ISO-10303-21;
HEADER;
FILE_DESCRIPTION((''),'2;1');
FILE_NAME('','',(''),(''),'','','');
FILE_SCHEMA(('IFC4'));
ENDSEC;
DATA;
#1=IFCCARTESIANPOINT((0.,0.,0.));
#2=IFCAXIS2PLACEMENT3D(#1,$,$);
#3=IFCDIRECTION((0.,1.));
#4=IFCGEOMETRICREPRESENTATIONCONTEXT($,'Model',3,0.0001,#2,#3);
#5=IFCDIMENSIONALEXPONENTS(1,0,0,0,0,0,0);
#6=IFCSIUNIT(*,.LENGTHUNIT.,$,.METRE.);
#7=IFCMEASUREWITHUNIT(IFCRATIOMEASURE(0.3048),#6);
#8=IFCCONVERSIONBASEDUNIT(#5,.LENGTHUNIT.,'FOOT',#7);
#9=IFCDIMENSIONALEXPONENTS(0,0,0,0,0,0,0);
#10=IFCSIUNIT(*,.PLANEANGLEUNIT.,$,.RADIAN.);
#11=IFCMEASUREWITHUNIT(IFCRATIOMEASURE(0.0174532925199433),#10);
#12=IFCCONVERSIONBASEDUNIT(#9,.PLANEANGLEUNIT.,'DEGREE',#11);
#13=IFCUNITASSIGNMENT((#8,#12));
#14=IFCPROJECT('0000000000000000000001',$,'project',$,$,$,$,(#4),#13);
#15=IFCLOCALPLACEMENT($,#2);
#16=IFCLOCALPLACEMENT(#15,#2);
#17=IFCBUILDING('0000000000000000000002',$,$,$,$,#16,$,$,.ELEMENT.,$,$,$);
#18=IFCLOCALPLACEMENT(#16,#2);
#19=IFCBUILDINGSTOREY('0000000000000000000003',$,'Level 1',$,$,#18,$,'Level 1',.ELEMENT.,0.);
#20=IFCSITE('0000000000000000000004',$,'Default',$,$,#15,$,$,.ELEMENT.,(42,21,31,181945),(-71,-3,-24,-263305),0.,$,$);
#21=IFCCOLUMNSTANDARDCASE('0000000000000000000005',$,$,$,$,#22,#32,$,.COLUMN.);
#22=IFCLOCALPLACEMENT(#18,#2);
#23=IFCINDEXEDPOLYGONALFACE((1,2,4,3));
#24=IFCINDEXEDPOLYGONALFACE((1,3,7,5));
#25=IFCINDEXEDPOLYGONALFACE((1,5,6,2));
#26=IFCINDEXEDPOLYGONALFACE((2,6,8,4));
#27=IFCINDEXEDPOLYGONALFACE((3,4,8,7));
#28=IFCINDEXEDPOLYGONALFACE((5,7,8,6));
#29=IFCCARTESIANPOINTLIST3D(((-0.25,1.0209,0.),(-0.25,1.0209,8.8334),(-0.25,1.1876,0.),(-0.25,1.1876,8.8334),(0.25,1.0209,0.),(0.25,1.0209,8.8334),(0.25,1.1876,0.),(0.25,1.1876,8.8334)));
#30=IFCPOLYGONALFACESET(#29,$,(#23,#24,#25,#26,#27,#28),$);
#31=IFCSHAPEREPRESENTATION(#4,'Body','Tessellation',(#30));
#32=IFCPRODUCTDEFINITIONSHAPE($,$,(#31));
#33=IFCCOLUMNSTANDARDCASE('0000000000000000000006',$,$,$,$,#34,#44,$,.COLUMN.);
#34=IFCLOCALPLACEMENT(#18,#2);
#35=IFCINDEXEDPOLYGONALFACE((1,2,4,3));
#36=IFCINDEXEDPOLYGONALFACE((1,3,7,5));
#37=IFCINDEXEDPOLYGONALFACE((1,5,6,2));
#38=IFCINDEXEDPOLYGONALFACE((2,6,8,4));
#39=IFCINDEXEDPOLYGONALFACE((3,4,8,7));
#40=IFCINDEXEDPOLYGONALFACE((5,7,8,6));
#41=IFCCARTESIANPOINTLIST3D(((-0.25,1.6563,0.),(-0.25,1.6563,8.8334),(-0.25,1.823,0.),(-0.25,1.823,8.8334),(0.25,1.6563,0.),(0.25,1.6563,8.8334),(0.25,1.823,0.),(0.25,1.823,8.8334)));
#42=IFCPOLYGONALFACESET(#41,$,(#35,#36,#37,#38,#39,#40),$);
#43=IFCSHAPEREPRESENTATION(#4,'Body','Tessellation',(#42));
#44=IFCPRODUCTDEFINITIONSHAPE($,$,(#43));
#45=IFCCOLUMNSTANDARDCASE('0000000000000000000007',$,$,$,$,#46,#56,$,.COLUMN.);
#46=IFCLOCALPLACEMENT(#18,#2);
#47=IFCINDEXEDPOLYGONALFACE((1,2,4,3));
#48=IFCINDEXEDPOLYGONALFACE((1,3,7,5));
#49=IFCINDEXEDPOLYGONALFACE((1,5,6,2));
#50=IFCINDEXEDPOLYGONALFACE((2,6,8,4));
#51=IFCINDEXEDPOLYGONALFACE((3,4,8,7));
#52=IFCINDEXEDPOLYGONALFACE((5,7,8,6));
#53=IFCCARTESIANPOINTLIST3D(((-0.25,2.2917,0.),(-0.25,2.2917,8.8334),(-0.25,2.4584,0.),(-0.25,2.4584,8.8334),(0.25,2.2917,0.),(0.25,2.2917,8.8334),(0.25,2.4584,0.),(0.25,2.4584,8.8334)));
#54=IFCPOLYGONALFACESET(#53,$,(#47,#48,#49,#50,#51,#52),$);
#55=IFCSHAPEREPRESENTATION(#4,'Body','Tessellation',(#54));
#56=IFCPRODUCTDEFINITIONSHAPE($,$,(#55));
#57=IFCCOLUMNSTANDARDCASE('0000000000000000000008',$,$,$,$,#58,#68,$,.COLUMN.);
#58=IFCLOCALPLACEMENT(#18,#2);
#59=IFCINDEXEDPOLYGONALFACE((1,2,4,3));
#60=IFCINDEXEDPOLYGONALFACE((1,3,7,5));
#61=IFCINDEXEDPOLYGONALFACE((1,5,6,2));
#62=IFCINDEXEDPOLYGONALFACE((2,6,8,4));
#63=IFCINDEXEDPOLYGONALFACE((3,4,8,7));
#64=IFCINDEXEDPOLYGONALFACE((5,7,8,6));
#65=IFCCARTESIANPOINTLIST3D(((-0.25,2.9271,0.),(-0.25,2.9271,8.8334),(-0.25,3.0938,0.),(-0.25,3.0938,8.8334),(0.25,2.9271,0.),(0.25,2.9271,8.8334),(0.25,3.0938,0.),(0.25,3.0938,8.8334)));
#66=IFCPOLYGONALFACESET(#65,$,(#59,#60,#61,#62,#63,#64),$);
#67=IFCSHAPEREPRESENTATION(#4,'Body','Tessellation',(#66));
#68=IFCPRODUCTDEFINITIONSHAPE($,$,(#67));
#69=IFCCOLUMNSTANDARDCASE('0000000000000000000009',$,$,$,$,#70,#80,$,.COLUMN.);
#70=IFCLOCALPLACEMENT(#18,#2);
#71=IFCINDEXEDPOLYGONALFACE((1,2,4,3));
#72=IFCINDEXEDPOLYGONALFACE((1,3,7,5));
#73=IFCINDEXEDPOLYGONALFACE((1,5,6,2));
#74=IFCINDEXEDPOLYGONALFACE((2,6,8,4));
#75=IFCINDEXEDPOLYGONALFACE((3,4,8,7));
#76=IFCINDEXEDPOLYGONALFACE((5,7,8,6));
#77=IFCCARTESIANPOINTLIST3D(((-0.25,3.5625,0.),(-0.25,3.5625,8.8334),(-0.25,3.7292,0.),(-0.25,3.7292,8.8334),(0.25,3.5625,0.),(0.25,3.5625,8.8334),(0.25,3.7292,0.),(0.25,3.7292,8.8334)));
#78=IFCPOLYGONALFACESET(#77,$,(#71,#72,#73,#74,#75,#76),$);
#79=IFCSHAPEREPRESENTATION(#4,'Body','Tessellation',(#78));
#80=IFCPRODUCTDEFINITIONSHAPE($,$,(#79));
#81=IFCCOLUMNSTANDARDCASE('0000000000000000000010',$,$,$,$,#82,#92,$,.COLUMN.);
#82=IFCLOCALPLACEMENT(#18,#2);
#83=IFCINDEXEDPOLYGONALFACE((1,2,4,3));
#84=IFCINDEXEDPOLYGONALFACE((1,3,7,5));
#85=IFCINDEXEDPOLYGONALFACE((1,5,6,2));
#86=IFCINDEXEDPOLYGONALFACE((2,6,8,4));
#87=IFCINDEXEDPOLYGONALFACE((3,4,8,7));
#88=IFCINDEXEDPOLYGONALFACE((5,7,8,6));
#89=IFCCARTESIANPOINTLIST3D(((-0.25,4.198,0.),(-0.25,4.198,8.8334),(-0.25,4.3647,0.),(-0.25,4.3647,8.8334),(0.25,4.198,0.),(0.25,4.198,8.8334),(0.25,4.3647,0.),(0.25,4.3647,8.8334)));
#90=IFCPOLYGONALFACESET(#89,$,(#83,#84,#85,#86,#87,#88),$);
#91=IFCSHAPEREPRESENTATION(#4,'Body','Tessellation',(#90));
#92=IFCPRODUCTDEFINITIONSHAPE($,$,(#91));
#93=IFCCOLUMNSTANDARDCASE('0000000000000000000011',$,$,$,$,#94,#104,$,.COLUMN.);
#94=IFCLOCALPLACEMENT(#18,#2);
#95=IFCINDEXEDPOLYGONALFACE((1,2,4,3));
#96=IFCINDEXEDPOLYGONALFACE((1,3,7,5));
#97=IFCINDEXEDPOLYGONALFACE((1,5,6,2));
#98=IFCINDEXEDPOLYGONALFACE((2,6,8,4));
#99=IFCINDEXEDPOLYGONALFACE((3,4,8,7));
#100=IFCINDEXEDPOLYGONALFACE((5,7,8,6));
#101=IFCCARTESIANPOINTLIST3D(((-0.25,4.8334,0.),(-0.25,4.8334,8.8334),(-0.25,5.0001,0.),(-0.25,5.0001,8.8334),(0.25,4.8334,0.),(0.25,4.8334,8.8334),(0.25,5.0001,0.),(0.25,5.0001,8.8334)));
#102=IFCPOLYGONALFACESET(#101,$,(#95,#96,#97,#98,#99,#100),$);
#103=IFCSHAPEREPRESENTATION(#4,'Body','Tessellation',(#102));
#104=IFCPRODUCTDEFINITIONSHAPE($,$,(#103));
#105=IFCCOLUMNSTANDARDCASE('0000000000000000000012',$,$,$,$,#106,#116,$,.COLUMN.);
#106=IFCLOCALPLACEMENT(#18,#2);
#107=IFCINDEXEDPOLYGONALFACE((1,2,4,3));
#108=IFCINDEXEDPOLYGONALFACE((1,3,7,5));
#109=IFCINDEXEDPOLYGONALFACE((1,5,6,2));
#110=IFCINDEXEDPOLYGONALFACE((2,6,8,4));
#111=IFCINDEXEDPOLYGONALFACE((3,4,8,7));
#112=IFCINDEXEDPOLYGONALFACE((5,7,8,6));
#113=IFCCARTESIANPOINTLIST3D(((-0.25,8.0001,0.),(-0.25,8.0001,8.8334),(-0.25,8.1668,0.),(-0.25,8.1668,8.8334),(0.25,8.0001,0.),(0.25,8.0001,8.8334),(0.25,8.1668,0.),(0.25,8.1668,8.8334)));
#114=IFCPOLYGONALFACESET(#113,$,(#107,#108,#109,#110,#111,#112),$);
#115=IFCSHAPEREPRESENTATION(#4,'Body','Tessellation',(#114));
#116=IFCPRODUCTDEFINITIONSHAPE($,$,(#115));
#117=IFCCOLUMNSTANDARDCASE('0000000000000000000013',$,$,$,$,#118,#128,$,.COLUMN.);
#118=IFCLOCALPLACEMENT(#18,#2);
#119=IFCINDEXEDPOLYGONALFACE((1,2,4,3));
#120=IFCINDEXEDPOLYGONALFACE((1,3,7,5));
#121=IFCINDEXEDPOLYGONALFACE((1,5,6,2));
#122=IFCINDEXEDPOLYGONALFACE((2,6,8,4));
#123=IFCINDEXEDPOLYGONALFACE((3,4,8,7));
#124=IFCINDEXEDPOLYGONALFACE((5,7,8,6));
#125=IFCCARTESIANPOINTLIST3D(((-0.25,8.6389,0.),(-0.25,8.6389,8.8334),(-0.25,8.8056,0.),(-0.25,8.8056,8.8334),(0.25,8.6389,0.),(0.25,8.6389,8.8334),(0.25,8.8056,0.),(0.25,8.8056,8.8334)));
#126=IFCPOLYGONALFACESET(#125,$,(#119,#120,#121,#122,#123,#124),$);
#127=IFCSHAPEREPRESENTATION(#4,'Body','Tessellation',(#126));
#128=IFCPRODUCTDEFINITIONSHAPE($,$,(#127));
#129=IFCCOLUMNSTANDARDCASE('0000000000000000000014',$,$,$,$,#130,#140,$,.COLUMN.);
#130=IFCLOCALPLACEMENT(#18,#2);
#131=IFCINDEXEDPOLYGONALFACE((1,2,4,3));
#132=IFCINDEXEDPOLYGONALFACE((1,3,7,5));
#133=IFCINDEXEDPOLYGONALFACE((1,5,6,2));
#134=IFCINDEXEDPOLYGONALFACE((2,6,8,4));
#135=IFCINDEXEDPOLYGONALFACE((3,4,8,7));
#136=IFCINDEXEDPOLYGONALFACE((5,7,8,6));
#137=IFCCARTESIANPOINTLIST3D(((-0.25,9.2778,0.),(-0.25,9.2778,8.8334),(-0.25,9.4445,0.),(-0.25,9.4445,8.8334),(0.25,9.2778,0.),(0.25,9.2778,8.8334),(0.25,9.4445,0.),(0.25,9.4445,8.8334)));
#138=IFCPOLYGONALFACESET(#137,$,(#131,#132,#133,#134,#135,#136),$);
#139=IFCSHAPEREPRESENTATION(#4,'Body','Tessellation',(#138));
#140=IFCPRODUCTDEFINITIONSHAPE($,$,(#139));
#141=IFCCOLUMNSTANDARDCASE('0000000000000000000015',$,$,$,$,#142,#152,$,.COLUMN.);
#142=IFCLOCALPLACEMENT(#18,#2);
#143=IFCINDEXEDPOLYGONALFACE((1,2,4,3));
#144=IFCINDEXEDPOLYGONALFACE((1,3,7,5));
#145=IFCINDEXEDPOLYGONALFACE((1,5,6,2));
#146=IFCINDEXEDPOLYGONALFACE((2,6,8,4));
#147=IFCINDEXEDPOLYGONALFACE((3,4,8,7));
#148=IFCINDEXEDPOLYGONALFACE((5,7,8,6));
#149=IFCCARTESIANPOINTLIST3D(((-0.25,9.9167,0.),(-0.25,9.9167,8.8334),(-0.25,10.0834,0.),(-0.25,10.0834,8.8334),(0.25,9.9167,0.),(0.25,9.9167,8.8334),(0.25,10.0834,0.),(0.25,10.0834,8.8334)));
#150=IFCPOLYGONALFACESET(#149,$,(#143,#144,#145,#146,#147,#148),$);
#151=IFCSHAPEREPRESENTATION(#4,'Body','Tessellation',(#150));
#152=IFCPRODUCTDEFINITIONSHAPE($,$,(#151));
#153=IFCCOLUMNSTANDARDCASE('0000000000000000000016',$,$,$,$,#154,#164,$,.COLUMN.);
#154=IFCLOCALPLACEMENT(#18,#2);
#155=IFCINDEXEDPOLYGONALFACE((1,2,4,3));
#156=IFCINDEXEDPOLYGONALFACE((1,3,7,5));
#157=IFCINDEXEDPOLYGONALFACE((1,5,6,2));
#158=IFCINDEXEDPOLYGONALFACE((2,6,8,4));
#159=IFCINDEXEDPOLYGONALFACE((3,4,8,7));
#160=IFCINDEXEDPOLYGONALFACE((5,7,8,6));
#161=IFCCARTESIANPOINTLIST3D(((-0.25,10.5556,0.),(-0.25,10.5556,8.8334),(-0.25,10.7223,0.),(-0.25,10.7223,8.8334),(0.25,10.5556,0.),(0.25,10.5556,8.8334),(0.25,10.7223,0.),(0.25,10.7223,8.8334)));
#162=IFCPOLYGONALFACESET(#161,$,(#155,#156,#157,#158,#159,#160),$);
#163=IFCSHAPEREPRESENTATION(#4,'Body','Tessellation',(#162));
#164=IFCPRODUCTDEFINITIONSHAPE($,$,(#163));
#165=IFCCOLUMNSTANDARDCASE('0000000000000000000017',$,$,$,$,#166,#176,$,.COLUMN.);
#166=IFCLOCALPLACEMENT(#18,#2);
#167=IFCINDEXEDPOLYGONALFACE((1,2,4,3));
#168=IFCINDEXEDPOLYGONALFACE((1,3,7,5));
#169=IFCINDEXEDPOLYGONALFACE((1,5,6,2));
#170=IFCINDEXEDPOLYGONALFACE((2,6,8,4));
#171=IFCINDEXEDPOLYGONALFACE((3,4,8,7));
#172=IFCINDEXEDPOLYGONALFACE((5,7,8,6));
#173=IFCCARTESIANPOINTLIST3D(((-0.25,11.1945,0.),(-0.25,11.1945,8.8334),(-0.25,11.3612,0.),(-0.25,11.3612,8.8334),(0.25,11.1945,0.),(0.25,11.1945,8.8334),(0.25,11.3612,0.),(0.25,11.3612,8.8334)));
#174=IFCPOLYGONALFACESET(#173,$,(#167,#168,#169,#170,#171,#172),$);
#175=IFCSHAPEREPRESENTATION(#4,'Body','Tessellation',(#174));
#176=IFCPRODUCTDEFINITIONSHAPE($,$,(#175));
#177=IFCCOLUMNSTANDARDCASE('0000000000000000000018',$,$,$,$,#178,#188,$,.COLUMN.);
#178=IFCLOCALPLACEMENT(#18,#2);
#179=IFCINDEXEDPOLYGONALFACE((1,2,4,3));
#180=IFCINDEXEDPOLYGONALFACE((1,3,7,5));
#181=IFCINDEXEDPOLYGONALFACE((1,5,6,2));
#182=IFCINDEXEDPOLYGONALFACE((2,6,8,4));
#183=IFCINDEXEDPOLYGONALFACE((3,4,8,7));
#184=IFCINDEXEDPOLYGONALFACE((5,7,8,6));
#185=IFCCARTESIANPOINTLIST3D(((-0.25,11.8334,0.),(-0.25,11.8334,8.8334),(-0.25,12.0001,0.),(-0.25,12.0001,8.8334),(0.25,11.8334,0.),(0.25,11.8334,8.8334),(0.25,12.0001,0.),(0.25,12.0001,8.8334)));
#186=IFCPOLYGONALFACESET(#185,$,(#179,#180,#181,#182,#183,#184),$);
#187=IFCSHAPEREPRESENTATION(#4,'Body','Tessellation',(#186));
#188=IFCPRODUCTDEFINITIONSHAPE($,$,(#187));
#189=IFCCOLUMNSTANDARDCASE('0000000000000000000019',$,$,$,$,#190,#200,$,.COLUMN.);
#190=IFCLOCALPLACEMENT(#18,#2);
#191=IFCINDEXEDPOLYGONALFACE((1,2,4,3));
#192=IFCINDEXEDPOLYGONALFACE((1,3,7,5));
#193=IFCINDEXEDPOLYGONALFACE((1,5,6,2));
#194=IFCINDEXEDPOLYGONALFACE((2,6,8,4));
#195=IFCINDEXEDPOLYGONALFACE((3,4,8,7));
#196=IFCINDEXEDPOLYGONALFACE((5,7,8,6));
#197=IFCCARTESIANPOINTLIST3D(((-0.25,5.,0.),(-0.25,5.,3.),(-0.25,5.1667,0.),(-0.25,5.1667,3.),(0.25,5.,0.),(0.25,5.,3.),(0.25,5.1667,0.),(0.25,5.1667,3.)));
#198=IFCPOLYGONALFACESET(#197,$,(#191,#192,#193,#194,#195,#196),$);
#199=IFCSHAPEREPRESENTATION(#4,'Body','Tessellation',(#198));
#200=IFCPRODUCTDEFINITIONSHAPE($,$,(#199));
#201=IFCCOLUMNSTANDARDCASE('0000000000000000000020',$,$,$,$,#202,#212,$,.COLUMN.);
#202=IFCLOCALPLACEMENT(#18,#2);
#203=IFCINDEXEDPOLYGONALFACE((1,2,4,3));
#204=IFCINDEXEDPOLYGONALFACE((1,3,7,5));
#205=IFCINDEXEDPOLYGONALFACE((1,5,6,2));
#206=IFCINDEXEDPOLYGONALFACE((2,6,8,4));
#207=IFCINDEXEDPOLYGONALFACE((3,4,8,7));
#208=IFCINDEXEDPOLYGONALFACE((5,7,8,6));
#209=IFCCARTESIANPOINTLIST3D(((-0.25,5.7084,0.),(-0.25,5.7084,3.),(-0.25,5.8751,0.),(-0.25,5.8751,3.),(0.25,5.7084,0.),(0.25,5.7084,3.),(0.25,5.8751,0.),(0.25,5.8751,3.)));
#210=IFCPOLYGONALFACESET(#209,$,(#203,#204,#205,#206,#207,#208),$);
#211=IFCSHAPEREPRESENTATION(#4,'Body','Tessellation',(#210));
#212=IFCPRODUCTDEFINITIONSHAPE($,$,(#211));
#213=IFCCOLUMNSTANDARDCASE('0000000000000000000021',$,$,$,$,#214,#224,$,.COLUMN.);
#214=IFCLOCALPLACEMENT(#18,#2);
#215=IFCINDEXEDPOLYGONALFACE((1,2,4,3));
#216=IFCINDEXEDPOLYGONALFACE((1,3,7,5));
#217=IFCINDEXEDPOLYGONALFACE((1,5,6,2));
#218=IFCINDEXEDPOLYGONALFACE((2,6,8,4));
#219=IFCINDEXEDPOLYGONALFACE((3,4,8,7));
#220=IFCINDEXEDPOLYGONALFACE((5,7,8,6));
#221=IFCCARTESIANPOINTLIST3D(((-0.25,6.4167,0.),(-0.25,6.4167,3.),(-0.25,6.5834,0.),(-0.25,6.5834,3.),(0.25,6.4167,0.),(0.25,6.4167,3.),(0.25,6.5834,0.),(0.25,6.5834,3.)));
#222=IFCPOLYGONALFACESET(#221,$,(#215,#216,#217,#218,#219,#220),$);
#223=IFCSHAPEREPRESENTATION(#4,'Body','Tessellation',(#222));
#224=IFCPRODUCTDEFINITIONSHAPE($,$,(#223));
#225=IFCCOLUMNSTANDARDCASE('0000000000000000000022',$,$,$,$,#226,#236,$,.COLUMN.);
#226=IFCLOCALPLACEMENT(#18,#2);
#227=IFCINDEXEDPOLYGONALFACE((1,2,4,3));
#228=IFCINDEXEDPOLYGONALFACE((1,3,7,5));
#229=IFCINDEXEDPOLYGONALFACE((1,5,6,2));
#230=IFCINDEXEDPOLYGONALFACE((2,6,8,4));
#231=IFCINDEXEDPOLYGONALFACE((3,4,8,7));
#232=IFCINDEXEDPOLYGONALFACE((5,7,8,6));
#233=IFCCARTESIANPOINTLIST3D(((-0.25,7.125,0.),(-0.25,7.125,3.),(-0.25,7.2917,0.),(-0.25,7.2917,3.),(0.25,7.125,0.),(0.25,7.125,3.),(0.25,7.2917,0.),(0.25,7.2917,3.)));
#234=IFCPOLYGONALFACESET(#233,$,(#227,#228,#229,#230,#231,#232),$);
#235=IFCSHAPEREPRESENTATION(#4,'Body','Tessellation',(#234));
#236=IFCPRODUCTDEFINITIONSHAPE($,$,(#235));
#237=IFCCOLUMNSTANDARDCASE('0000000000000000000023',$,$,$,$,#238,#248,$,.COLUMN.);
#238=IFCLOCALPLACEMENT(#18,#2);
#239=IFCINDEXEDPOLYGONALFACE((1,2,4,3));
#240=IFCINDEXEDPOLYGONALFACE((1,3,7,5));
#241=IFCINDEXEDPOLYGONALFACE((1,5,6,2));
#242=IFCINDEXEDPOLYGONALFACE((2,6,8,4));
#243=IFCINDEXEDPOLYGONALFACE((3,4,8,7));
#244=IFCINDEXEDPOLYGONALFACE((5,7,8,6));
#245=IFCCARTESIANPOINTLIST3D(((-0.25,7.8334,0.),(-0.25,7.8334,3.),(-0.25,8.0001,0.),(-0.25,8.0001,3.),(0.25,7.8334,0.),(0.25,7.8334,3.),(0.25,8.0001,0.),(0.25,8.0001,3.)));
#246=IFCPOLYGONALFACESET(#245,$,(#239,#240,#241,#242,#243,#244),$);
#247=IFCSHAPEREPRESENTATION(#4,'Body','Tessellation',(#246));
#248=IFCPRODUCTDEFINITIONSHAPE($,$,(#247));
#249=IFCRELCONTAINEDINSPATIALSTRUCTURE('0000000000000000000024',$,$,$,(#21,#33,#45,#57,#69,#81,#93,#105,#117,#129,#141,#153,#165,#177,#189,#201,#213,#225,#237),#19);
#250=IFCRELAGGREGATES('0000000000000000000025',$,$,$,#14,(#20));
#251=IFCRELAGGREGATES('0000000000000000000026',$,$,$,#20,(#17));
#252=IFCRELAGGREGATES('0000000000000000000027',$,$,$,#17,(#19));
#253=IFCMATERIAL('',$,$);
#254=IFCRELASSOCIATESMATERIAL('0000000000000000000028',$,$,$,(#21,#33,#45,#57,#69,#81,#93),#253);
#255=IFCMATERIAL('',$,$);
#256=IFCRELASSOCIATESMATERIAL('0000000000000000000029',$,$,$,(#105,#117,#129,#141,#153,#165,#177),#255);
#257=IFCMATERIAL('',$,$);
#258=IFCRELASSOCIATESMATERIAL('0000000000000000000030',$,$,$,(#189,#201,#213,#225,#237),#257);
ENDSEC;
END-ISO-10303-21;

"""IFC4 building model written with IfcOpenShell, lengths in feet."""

from ifc_helpers import new_model, entity, si_unit, converted_unit, direction, frame, origin, place, context, project, spatial, rectangle, extrude, material, element, save


model = new_model("IFC4")

# Units and contexts
model_context = context("Model", 3, precision=0.0001, world=origin(), true_north=direction((0.0, 1.0)))
ifc_project = project(units=[converted_unit("LENGTHUNIT", "FOOT", entity("IfcRatioMeasure", 0.3048), si_unit("LENGTHUNIT", "METRE"), dimensions=[1, 0, 0, 0, 0, 0, 0]), converted_unit("PLANEANGLEUNIT", "DEGREE", entity("IfcRatioMeasure", 0.0174532925199433), si_unit("PLANEANGLEUNIT", "RADIAN"), dimensions=[0, 0, 0, 0, 0, 0, 0])], contexts=[model_context])

# Site, building, storey
site_placement = place(None, origin())
site = spatial("IfcSite", under=ifc_project, at=site_placement, Name="Default", CompositionType="ELEMENT", RefLatitude=(42, 21, 31, 181945), RefLongitude=(-71, -3, -24, -263305), RefElevation=0.0)
building_placement = place(site_placement, origin())
building = spatial("IfcBuilding", under=site, at=building_placement, CompositionType="ELEMENT")
storey_placement = place(building_placement, origin())
storey = spatial("IfcBuildingStorey", under=building, at=storey_placement, Name="Level 1", LongName="Level 1", CompositionType="ELEMENT", Elevation=0.0)

# Columns
ifc_material_1 = material(Name="")
placement_1 = place(storey_placement, frame((0.0, -0.25, 0.0), z_axis=(0.0, 0.0, 1.0), x_axis=(0.0, 1.0, 0.0)))
for number, where, z_axis, x_axis in (
    (1, (1.3542, 0.0, 0.0), (0.0, 0.0, 1.0), (1.0, 0.0, 0.0)),
    (2, (1.9896, 0.0, 0.0), (0.0, 0.0, 1.0), (1.0, 0.0, 0.0)),
    (3, (2.625, 0.0, 0.0), (0.0, 0.0, 1.0), (1.0, 0.0, 0.0)),
    (4, (3.2604, 0.0, 0.0), (0.0, 0.0, 1.0), (1.0, 0.0, 0.0)),
    (5, (3.8958, 0.0, 0.0), (0.0, 0.0, 1.0), (1.0, 0.0, 0.0)),
    (6, (4.5313, 0.0, 0.0), (0.0, 0.0, 1.0), (1.0, 0.0, 0.0)),
    (7, (5.1667, 0.0, 0.0), (0.0, 0.0, 1.0), (1.0, 0.0, 0.0)),
):
    element("IfcColumnStandardCase", number, at=place(placement_1, frame(where, z_axis=z_axis, x_axis=x_axis)), inside=storey, material=ifc_material_1, PredefinedType="COLUMN", context=model_context, shape_type="SweptSolid", body=[
        extrude(rectangle(XDim=0.1667, YDim=0.5), origin(), (0.0, 0.0, 1.0), 8.8334),
    ])
ifc_material_2 = material(Name="")
for number, where, z_axis, x_axis in (
    (8, (8.3334, 0.0, 0.0), (0.0, 0.0, 1.0), (1.0, 0.0, 0.0)),
    (9, (8.9722, 0.0, 0.0), (0.0, 0.0, 1.0), (1.0, 0.0, 0.0)),
    (10, (9.6111, 0.0, 0.0), (0.0, 0.0, 1.0), (1.0, 0.0, 0.0)),
    (11, (10.25, 0.0, 0.0), (0.0, 0.0, 1.0), (1.0, 0.0, 0.0)),
    (12, (10.8889, 0.0, 0.0), (0.0, 0.0, 1.0), (1.0, 0.0, 0.0)),
    (13, (11.5278, 0.0, 0.0), (0.0, 0.0, 1.0), (1.0, 0.0, 0.0)),
    (14, (12.1667, 0.0, 0.0), (0.0, 0.0, 1.0), (1.0, 0.0, 0.0)),
):
    element("IfcColumnStandardCase", number, at=place(placement_1, frame(where, z_axis=z_axis, x_axis=x_axis)), inside=storey, material=ifc_material_2, PredefinedType="COLUMN", context=model_context, shape_type="SweptSolid", body=[
        extrude(rectangle(XDim=0.1667, YDim=0.5), origin(), (0.0, 0.0, 1.0), 8.8334),
    ])
ifc_material_3 = material(Name="")
for number, where, z_axis, x_axis in (
    (15, (5.3333, 0.0, 0.0), (0.0, 0.0, 1.0), (1.0, 0.0, 0.0)),
    (16, (6.0417, 0.0, 0.0), (0.0, 0.0, 1.0), (1.0, 0.0, 0.0)),
    (17, (6.75, 0.0, 0.0), (0.0, 0.0, 1.0), (1.0, 0.0, 0.0)),
    (18, (7.4583, 0.0, 0.0), (0.0, 0.0, 1.0), (1.0, 0.0, 0.0)),
    (19, (8.1667, 0.0, 0.0), (0.0, 0.0, 1.0), (1.0, 0.0, 0.0)),
):
    element("IfcColumnStandardCase", number, at=place(placement_1, frame(where, z_axis=z_axis, x_axis=x_axis)), inside=storey, material=ifc_material_3, PredefinedType="COLUMN", context=model_context, shape_type="SweptSolid", body=[
        extrude(rectangle(XDim=0.1667, YDim=0.5), origin(), (0.0, 0.0, 1.0), 3.0),
    ])

save(model, "model.ifc")
